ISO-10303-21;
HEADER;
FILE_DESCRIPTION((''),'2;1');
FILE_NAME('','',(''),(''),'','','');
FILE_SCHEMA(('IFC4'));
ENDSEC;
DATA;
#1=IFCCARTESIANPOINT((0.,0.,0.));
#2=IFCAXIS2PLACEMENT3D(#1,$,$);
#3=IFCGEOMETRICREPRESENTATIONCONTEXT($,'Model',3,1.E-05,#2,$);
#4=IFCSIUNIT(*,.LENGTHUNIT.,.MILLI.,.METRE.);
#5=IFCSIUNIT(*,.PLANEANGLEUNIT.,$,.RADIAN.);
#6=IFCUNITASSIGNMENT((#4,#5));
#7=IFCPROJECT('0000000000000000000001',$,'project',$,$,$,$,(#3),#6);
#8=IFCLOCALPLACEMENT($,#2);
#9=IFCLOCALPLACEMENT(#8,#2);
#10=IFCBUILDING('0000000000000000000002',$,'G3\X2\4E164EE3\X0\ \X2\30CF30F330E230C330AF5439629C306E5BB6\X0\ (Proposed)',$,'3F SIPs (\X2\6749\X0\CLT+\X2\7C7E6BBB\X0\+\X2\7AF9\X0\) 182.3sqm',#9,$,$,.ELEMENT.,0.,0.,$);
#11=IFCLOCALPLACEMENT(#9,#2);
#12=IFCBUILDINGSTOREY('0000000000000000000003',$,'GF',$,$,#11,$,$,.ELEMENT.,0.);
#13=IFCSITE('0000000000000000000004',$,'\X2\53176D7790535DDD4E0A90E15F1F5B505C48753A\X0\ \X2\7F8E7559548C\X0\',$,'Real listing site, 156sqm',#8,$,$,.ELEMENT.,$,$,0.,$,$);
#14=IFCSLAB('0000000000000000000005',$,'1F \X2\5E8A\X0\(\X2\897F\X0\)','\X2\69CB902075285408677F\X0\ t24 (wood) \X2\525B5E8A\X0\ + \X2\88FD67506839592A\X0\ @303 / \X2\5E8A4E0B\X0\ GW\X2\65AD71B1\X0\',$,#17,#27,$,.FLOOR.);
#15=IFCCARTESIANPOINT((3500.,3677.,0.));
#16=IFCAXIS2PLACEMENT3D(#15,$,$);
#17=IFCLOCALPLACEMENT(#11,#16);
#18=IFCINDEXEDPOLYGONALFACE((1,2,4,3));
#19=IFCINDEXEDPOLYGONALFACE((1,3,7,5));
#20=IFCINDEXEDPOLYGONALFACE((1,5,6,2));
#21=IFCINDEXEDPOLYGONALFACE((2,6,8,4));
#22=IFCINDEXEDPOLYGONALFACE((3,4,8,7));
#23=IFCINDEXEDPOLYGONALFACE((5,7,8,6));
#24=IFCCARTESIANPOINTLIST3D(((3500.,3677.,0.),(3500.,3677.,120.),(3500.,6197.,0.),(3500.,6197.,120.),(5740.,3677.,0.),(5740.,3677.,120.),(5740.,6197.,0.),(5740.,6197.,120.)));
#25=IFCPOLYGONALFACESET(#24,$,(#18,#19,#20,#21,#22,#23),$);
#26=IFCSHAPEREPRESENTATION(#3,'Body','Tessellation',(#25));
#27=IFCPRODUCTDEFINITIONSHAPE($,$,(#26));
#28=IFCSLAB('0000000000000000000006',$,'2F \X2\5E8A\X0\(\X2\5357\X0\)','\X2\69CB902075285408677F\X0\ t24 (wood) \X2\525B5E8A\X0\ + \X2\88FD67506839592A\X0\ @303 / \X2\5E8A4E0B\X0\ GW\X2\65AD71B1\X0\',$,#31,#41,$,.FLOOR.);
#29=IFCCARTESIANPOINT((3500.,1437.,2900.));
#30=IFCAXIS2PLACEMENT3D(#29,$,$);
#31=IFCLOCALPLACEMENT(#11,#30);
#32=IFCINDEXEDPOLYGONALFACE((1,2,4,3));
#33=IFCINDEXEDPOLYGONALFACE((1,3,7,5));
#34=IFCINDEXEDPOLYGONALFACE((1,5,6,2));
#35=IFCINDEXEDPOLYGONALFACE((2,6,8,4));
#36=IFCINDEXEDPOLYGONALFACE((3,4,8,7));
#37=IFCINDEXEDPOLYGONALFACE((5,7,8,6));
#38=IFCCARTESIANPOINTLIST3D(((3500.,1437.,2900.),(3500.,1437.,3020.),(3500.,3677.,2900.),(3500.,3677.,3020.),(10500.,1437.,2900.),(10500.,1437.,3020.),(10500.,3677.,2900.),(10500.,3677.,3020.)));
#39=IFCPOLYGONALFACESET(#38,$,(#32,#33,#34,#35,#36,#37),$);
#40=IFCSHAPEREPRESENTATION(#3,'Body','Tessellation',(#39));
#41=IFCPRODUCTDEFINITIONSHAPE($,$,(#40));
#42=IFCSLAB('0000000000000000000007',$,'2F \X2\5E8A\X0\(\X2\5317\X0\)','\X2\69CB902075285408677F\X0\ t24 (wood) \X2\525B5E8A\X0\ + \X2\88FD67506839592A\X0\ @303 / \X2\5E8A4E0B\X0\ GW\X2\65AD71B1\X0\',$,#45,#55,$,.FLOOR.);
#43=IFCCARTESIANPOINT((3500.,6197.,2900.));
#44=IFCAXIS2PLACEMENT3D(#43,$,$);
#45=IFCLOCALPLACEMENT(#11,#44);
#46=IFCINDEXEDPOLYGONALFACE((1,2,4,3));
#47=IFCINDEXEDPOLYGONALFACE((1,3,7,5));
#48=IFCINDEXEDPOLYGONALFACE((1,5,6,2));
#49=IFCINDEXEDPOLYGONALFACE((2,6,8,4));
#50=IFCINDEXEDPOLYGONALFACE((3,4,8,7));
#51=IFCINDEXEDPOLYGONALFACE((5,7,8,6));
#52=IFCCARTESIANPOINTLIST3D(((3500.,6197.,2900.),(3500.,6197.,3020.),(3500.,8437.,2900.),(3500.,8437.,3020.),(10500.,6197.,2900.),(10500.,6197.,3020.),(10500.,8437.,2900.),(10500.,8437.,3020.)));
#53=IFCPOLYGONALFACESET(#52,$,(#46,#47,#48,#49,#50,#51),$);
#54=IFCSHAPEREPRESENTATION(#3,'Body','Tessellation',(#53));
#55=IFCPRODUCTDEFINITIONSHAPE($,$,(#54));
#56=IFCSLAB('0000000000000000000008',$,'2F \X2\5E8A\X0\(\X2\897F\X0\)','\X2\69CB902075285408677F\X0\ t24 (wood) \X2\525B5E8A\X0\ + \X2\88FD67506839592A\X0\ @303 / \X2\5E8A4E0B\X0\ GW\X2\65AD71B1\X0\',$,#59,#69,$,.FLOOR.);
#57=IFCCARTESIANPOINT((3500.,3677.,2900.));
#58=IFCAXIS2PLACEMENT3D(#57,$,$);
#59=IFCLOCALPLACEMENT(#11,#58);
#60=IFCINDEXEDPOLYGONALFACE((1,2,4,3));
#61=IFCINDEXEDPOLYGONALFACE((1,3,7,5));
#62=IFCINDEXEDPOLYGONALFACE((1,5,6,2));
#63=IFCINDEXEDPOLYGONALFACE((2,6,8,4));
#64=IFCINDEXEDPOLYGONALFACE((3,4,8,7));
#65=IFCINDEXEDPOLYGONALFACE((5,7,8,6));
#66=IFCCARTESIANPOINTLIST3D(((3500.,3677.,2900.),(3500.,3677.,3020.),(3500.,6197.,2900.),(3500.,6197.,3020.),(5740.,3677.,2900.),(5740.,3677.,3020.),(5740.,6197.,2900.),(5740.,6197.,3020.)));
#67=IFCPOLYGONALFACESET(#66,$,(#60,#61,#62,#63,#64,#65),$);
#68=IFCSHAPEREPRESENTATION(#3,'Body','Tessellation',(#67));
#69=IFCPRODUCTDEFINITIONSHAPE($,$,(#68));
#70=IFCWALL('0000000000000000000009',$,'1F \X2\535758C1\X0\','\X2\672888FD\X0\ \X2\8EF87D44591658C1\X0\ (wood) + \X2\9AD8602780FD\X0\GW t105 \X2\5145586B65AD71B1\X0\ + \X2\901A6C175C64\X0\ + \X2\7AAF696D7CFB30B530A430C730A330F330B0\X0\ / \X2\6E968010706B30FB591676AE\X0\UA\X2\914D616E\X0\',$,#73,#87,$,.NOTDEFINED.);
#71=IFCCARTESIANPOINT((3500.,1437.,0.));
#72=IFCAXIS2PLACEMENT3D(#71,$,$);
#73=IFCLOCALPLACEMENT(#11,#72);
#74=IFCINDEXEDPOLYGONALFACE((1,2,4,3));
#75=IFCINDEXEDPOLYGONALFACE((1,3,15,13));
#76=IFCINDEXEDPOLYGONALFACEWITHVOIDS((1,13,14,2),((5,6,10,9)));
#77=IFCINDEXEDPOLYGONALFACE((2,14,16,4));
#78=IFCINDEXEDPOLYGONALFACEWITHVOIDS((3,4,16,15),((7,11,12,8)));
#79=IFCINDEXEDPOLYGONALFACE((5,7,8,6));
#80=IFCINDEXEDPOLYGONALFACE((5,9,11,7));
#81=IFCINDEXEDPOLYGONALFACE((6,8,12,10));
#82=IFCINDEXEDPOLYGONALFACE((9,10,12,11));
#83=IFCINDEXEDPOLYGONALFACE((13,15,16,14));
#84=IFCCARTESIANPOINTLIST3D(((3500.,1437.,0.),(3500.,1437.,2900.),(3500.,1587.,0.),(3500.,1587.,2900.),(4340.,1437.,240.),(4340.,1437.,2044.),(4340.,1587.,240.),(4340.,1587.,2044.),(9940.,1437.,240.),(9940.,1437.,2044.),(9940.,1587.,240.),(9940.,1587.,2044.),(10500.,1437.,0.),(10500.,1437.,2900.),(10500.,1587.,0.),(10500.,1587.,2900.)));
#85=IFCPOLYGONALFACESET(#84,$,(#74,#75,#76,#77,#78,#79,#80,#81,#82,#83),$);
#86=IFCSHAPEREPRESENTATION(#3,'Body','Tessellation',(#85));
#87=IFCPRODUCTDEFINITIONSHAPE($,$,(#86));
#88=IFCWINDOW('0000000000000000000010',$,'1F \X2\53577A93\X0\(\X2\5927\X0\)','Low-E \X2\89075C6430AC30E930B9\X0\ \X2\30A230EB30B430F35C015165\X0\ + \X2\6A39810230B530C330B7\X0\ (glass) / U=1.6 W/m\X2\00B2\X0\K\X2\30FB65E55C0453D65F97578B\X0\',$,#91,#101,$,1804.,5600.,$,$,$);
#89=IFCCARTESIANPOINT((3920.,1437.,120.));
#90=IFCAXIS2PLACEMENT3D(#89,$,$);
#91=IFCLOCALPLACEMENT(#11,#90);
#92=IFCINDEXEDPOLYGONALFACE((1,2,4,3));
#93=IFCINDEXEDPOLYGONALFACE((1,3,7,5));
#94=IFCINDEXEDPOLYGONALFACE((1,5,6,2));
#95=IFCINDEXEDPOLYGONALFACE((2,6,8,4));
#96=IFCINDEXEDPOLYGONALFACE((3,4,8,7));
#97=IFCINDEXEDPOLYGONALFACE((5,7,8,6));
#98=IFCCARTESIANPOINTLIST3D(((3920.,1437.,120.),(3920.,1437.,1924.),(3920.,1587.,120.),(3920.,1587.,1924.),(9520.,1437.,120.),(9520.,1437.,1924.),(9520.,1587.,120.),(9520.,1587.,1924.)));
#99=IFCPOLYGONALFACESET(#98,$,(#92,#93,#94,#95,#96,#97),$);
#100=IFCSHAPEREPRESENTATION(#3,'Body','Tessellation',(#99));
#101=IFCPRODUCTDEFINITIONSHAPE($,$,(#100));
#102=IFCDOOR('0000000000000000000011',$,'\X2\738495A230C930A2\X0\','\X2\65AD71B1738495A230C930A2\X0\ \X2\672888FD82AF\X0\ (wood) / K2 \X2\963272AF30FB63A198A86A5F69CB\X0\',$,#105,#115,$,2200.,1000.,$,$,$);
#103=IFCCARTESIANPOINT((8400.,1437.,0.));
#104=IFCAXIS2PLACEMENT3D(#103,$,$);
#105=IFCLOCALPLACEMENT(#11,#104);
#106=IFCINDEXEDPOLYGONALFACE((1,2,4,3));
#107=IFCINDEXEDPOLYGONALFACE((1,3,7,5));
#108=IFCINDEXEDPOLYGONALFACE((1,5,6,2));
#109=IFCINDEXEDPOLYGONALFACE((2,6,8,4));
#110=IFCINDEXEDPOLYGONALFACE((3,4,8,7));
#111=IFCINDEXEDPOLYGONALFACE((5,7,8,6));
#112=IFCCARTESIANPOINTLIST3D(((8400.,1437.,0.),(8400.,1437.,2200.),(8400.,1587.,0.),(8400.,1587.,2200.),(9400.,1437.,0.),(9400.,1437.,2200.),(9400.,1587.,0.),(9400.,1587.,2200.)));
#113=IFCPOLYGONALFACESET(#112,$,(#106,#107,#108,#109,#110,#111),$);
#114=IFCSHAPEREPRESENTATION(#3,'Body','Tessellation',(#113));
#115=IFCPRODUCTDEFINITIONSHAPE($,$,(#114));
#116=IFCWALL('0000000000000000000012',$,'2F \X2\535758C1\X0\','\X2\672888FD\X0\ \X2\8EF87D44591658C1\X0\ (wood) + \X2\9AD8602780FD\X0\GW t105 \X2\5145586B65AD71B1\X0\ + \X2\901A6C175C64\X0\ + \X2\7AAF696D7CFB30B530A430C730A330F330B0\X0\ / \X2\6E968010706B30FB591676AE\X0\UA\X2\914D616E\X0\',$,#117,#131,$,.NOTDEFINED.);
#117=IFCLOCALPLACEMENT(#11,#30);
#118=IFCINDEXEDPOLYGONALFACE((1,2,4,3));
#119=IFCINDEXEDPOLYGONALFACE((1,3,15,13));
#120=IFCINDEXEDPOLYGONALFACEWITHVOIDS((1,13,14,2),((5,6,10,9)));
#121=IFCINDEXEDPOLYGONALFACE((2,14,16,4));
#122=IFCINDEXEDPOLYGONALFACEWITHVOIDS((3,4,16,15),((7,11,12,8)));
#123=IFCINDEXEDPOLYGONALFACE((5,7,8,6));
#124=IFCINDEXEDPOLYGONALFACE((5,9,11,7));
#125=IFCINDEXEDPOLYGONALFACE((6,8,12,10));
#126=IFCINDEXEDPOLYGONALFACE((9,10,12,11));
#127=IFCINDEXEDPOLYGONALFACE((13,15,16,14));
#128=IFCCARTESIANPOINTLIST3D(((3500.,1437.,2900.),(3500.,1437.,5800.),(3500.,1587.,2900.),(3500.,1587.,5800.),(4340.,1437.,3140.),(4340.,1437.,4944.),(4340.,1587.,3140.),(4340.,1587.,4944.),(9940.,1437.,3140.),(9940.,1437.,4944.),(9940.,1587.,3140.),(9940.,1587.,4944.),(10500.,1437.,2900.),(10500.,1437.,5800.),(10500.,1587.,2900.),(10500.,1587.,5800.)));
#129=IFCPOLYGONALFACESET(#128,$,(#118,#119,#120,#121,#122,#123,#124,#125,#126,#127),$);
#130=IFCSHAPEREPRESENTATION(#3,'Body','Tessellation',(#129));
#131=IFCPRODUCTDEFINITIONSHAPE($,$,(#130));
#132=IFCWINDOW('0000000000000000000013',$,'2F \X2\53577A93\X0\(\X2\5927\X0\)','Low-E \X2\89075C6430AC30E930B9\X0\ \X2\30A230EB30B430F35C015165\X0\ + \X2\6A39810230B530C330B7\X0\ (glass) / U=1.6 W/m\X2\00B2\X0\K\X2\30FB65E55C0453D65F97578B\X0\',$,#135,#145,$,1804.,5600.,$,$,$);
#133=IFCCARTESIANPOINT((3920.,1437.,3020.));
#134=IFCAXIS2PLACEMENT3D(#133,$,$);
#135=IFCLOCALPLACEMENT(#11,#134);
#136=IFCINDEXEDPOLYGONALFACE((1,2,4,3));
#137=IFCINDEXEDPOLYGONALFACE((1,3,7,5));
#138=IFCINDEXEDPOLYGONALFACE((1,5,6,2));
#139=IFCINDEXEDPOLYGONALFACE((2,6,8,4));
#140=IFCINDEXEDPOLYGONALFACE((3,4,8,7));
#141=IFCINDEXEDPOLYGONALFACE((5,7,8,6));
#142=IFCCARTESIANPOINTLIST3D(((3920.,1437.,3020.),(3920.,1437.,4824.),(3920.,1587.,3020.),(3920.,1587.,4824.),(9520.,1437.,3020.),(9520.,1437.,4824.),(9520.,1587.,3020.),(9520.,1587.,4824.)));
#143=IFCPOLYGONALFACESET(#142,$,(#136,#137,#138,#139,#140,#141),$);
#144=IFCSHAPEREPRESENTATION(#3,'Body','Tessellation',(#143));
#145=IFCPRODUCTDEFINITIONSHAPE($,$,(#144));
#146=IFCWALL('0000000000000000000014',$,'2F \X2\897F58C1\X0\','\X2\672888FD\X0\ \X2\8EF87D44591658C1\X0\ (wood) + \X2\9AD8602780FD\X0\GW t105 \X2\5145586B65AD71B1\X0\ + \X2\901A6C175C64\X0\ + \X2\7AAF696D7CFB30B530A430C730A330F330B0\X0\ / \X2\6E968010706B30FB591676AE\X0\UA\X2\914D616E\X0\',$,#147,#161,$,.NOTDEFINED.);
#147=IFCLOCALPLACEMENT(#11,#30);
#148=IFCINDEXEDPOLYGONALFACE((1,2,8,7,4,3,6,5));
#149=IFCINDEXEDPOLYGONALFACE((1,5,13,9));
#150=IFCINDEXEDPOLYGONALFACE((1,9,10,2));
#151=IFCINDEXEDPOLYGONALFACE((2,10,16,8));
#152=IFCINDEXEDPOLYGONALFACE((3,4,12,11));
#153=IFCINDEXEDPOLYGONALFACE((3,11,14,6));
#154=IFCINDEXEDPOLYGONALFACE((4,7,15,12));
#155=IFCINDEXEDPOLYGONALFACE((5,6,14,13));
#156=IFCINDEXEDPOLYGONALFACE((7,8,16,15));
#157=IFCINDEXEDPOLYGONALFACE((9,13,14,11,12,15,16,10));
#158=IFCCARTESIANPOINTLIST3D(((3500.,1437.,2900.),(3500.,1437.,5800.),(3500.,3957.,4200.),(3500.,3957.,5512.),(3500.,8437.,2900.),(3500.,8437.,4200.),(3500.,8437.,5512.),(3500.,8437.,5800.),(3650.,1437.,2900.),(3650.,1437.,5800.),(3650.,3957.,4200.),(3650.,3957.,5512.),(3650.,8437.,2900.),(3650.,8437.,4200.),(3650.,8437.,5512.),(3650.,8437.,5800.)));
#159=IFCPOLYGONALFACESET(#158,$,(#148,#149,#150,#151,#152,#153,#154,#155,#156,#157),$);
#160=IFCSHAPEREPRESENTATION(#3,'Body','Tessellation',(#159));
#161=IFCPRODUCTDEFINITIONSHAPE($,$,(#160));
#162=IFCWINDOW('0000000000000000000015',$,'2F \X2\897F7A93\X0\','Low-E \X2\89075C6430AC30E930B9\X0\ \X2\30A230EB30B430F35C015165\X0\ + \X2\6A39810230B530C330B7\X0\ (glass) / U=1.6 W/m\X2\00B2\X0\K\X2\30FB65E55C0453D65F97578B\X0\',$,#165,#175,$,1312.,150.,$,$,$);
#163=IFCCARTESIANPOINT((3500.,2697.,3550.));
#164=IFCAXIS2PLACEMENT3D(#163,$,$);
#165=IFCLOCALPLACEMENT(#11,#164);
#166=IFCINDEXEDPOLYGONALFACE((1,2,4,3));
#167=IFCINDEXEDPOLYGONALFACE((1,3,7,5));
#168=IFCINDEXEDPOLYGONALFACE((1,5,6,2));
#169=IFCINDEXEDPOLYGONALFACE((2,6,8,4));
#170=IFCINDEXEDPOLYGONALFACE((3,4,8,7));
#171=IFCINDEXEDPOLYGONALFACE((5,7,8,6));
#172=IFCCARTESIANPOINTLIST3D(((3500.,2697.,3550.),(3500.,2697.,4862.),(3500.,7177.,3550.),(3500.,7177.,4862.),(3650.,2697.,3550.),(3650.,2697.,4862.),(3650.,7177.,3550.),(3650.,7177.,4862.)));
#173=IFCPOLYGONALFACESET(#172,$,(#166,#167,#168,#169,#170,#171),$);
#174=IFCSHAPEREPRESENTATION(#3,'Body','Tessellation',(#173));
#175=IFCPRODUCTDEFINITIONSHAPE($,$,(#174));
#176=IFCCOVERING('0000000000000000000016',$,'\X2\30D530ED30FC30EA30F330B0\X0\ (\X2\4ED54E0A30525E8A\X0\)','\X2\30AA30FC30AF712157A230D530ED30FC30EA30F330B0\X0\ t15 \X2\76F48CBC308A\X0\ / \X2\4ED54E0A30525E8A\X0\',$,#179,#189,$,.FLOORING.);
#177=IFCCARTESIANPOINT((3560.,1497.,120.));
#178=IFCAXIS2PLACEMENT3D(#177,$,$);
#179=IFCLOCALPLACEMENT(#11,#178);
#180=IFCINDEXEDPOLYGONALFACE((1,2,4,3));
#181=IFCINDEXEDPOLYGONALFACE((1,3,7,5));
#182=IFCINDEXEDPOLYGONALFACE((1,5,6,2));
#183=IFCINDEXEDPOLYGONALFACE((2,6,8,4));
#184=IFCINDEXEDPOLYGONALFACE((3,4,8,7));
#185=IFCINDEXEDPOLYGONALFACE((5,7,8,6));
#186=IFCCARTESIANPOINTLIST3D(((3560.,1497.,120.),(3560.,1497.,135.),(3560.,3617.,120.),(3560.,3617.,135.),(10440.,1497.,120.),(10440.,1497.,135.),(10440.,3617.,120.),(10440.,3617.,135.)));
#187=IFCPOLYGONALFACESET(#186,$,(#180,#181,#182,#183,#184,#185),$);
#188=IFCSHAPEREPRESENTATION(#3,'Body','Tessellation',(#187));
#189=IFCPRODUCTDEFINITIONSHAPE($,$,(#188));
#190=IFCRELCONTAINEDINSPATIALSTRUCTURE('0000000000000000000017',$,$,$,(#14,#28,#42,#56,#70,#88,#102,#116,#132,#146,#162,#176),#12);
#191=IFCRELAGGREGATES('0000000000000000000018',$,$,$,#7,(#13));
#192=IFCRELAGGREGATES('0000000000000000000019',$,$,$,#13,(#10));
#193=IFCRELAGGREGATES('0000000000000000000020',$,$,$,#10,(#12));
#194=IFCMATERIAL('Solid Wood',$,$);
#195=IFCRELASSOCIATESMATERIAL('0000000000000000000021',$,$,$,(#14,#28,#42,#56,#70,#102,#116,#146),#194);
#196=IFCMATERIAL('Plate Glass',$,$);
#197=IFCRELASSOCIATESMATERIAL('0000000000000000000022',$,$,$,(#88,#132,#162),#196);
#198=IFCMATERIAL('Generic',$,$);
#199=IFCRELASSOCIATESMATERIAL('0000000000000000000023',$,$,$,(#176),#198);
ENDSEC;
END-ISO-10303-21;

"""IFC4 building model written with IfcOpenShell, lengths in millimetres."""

from ifc_helpers import new_model, si_unit, frame, frame_2d, origin, place, context, project, spatial, rectangle, extrude, material, element, fill, save


model = new_model("IFC4")

# Units and contexts
model_context = context("Model", 3, precision=1e-05, world=origin())
ifc_project = project(units=[si_unit("LENGTHUNIT", "METRE", prefix="MILLI"), si_unit("PLANEANGLEUNIT", "RADIAN")], contexts=[model_context])

# Site, building, storey
site_placement = place(None, origin())
site = spatial("IfcSite", under=ifc_project, at=site_placement, Name="北海道川上郡弟子屈町 美留和", ObjectType="Real listing site, 156sqm", CompositionType="ELEMENT", RefElevation=0.0)
building_placement = place(site_placement, origin())
building = spatial("IfcBuilding", under=site, at=building_placement, Name="G3世代 ハンモック吹抜の家 (Proposed)", ObjectType="3F SIPs (杉CLT+籾殻+竹) 182.3sqm", CompositionType="ELEMENT", ElevationOfRefHeight=0.0, ElevationOfTerrain=0.0)
storey_placement = place(building_placement, origin())
storey = spatial("IfcBuildingStorey", under=building, at=storey_placement, Name="GF", CompositionType="ELEMENT", Elevation=0.0)

# Slabs
ifc_material_1 = material(Name="Solid Wood")
slab_1_placement = place(storey_placement, frame((3500.0, 3677.0, 0.0)))
element("IfcSlab", 1, at=slab_1_placement, inside=storey, material=ifc_material_1, Name="1F 床(西)", Description="構造用合板 t24 (wood) 剛床 + 製材根太 @303 / 床下 GW断熱", PredefinedType="FLOOR", context=model_context, shape_type="SweptSolid", body=[
    extrude(rectangle(XDim=2240.0, YDim=2520.0, at=frame_2d((1120.0, 1260.0))), frame((3500.0, 3677.0, 0.0)), (0.0, 0.0, 1.0), 120.0),
])
slab_2_placement = place(storey_placement, frame((3500.0, 1437.0, 2900.0)))
element("IfcSlab", 2, at=slab_2_placement, inside=storey, material=ifc_material_1, Name="2F 床(南)", Description="構造用合板 t24 (wood) 剛床 + 製材根太 @303 / 床下 GW断熱", PredefinedType="FLOOR", context=model_context, shape_type="SweptSolid", body=[
    extrude(rectangle(XDim=7000.0, YDim=2240.0, at=frame_2d((3500.0, 1120.0))), frame((3500.0, 1437.0, 2900.0)), (0.0, 0.0, 1.0), 120.0),
])
slab_3_placement = place(storey_placement, frame((3500.0, 6197.0, 2900.0)))
element("IfcSlab", 3, at=slab_3_placement, inside=storey, material=ifc_material_1, Name="2F 床(北)", Description="構造用合板 t24 (wood) 剛床 + 製材根太 @303 / 床下 GW断熱", PredefinedType="FLOOR", context=model_context, shape_type="SweptSolid", body=[
    extrude(rectangle(XDim=7000.0, YDim=2240.0, at=frame_2d((3500.0, 1120.0))), frame((3500.0, 6197.0, 2900.0)), (0.0, 0.0, 1.0), 120.0),
])
slab_4_placement = place(storey_placement, frame((3500.0, 3677.0, 2900.0)))
element("IfcSlab", 4, at=slab_4_placement, inside=storey, material=ifc_material_1, Name="2F 床(西)", Description="構造用合板 t24 (wood) 剛床 + 製材根太 @303 / 床下 GW断熱", PredefinedType="FLOOR", context=model_context, shape_type="SweptSolid", body=[
    extrude(rectangle(XDim=2240.0, YDim=2520.0, at=frame_2d((1120.0, 1260.0))), frame((3500.0, 3677.0, 2900.0)), (0.0, 0.0, 1.0), 120.0),
])

# Wall, openings, window, door
wall_1_placement = place(storey_placement, frame((3500.0, 1437.0, 0.0)))
wall_1 = element("IfcWall", 5, at=wall_1_placement, inside=storey, material=ifc_material_1, Name="1F 南壁", Description="木製 軸組外壁 (wood) + 高性能GW t105 充填断熱 + 通気層 + 窯業系サイディング / 準耐火・外皮UA配慮", PredefinedType="NOTDEFINED", context=model_context, shape_type="SweptSolid", body=[
    extrude(rectangle(XDim=7000.0, YDim=150.0, at=frame_2d((3500.0, 75.0))), frame((3500.0, 1437.0, 0.0)), (0.0, 0.0, 1.0), 2900.0),
])
opening_1_placement = place(storey_placement, frame((3920.0, 1437.0, 120.0)))
opening_1 = element("IfcOpeningElement", 6, at=opening_1_placement, cuts=wall_1, PredefinedType="NOTDEFINED", context=model_context, shape_type="SweptSolid", body=[
    extrude(rectangle(XDim=5600.0, YDim=150.0, at=frame_2d((2800.0, 75.0))), frame((3920.0, 1437.0, 120.0)), (0.0, 0.0, 1.0), 1804.0),
])
opening_2_placement = place(storey_placement, frame((8400.0, 1437.0, 0.0)))
opening_2 = element("IfcOpeningElement", 7, at=opening_2_placement, cuts=wall_1, PredefinedType="NOTDEFINED", context=model_context, shape_type="SweptSolid", body=[
    extrude(rectangle(XDim=1000.0, YDim=150.0, at=frame_2d((500.0, 75.0))), frame((8400.0, 1437.0, 0.0)), (0.0, 0.0, 1.0), 2200.0),
])
ifc_material_2 = material(Name="Plate Glass")
window_1_placement = place(storey_placement, frame((3920.0, 1437.0, 120.0)))
window_1 = element("IfcWindow", 8, at=window_1_placement, inside=storey, material=ifc_material_2, Name="1F 南窓(大)", Description="Low-E 複層ガラス アルゴン封入 + 樹脂サッシ (glass) / U=1.6 W/m²K・日射取得型", OverallHeight=1804.0, OverallWidth=5600.0, context=model_context, shape_type="SweptSolid", body=[
    extrude(rectangle(XDim=5600.0, YDim=150.0, at=frame_2d((2800.0, 75.0))), frame((3920.0, 1437.0, 120.0)), (0.0, 0.0, 1.0), 1804.0),
])
fill(opening_1, window_1)
door_placement = place(storey_placement, frame((8400.0, 1437.0, 0.0)))
door = element("IfcDoor", 9, at=door_placement, inside=storey, material=ifc_material_1, Name="玄関ドア", Description="断熱玄関ドア 木製芯 (wood) / K2 防犯・採風機構", OverallHeight=2200.0, OverallWidth=1000.0, context=model_context, shape_type="SweptSolid", body=[
    extrude(rectangle(XDim=1000.0, YDim=150.0, at=frame_2d((500.0, 75.0))), frame((8400.0, 1437.0, 0.0)), (0.0, 0.0, 1.0), 2200.0),
])
fill(opening_2, door)

# Wall, opening, window
wall_2_placement = place(storey_placement, frame((3500.0, 1437.0, 2900.0)))
wall_2 = element("IfcWall", 10, at=wall_2_placement, inside=storey, material=ifc_material_1, Name="2F 南壁", Description="木製 軸組外壁 (wood) + 高性能GW t105 充填断熱 + 通気層 + 窯業系サイディング / 準耐火・外皮UA配慮", PredefinedType="NOTDEFINED", context=model_context, shape_type="SweptSolid", body=[
    extrude(rectangle(XDim=7000.0, YDim=150.0, at=frame_2d((3500.0, 75.0))), frame((3500.0, 1437.0, 2900.0)), (0.0, 0.0, 1.0), 2900.0),
])
opening_3_placement = place(storey_placement, frame((3920.0, 1437.0, 3020.0)))
opening_3 = element("IfcOpeningElement", 11, at=opening_3_placement, cuts=wall_2, PredefinedType="NOTDEFINED", context=model_context, shape_type="SweptSolid", body=[
    extrude(rectangle(XDim=5600.0, YDim=150.0, at=frame_2d((2800.0, 75.0))), frame((3920.0, 1437.0, 3020.0)), (0.0, 0.0, 1.0), 1804.0),
])
window_2_placement = place(storey_placement, frame((3920.0, 1437.0, 3020.0)))
window_2 = element("IfcWindow", 12, at=window_2_placement, inside=storey, material=ifc_material_2, Name="2F 南窓(大)", Description="Low-E 複層ガラス アルゴン封入 + 樹脂サッシ (glass) / U=1.6 W/m²K・日射取得型", OverallHeight=1804.0, OverallWidth=5600.0, context=model_context, shape_type="SweptSolid", body=[
    extrude(rectangle(XDim=5600.0, YDim=150.0, at=frame_2d((2800.0, 75.0))), frame((3920.0, 1437.0, 3020.0)), (0.0, 0.0, 1.0), 1804.0),
])
fill(opening_3, window_2)

# Wall, opening, window
wall_3_placement = place(storey_placement, frame((3500.0, 1437.0, 2900.0)))
wall_3 = element("IfcWall", 13, at=wall_3_placement, inside=storey, material=ifc_material_1, Name="2F 西壁", Description="木製 軸組外壁 (wood) + 高性能GW t105 充填断熱 + 通気層 + 窯業系サイディング / 準耐火・外皮UA配慮", PredefinedType="NOTDEFINED", context=model_context, shape_type="SweptSolid", body=[
    extrude(rectangle(XDim=150.0, YDim=7000.0, at=frame_2d((75.0, 3500.0))), frame((3500.0, 1437.0, 2900.0)), (0.0, 0.0, 1.0), 2900.0),
])
opening_4_placement = place(storey_placement, frame((3500.0, 2697.0, 3550.0)))
opening_4 = element("IfcOpeningElement", 14, at=opening_4_placement, cuts=wall_3, PredefinedType="NOTDEFINED", context=model_context, shape_type="SweptSolid", body=[
    extrude(rectangle(XDim=150.0, YDim=4480.0, at=frame_2d((75.0, 2240.0))), frame((3500.0, 2697.0, 3550.0)), (0.0, 0.0, 1.0), 1312.0),
])
window_3_placement = place(storey_placement, frame((3500.0, 2697.0, 3550.0)))
window_3 = element("IfcWindow", 15, at=window_3_placement, inside=storey, material=ifc_material_2, Name="2F 西窓", Description="Low-E 複層ガラス アルゴン封入 + 樹脂サッシ (glass) / U=1.6 W/m²K・日射取得型", OverallHeight=1312.0, OverallWidth=150.0, context=model_context, shape_type="SweptSolid", body=[
    extrude(rectangle(XDim=150.0, YDim=4480.0, at=frame_2d((75.0, 2240.0))), frame((3500.0, 2697.0, 3550.0)), (0.0, 0.0, 1.0), 1312.0),
])
fill(opening_4, window_3)

# Covering
ifc_material_3 = material(Name="Generic")
covering_1_placement = place(storey_placement, frame((3560.0, 1497.0, 120.0)))
element("IfcCovering", 16, at=covering_1_placement, inside=storey, material=ifc_material_3, Name="フローリング (仕上げ床)", Description="オーク無垢フローリング t15 直貼り / 仕上げ床", PredefinedType="FLOORING", context=model_context, shape_type="SweptSolid", body=[
    extrude(rectangle(XDim=6880.0, YDim=2120.0, at=frame_2d((3440.0, 1060.0))), frame((3560.0, 1497.0, 120.0)), (0.0, 0.0, 1.0), 15.0),
])

save(model, "model.ifc")
